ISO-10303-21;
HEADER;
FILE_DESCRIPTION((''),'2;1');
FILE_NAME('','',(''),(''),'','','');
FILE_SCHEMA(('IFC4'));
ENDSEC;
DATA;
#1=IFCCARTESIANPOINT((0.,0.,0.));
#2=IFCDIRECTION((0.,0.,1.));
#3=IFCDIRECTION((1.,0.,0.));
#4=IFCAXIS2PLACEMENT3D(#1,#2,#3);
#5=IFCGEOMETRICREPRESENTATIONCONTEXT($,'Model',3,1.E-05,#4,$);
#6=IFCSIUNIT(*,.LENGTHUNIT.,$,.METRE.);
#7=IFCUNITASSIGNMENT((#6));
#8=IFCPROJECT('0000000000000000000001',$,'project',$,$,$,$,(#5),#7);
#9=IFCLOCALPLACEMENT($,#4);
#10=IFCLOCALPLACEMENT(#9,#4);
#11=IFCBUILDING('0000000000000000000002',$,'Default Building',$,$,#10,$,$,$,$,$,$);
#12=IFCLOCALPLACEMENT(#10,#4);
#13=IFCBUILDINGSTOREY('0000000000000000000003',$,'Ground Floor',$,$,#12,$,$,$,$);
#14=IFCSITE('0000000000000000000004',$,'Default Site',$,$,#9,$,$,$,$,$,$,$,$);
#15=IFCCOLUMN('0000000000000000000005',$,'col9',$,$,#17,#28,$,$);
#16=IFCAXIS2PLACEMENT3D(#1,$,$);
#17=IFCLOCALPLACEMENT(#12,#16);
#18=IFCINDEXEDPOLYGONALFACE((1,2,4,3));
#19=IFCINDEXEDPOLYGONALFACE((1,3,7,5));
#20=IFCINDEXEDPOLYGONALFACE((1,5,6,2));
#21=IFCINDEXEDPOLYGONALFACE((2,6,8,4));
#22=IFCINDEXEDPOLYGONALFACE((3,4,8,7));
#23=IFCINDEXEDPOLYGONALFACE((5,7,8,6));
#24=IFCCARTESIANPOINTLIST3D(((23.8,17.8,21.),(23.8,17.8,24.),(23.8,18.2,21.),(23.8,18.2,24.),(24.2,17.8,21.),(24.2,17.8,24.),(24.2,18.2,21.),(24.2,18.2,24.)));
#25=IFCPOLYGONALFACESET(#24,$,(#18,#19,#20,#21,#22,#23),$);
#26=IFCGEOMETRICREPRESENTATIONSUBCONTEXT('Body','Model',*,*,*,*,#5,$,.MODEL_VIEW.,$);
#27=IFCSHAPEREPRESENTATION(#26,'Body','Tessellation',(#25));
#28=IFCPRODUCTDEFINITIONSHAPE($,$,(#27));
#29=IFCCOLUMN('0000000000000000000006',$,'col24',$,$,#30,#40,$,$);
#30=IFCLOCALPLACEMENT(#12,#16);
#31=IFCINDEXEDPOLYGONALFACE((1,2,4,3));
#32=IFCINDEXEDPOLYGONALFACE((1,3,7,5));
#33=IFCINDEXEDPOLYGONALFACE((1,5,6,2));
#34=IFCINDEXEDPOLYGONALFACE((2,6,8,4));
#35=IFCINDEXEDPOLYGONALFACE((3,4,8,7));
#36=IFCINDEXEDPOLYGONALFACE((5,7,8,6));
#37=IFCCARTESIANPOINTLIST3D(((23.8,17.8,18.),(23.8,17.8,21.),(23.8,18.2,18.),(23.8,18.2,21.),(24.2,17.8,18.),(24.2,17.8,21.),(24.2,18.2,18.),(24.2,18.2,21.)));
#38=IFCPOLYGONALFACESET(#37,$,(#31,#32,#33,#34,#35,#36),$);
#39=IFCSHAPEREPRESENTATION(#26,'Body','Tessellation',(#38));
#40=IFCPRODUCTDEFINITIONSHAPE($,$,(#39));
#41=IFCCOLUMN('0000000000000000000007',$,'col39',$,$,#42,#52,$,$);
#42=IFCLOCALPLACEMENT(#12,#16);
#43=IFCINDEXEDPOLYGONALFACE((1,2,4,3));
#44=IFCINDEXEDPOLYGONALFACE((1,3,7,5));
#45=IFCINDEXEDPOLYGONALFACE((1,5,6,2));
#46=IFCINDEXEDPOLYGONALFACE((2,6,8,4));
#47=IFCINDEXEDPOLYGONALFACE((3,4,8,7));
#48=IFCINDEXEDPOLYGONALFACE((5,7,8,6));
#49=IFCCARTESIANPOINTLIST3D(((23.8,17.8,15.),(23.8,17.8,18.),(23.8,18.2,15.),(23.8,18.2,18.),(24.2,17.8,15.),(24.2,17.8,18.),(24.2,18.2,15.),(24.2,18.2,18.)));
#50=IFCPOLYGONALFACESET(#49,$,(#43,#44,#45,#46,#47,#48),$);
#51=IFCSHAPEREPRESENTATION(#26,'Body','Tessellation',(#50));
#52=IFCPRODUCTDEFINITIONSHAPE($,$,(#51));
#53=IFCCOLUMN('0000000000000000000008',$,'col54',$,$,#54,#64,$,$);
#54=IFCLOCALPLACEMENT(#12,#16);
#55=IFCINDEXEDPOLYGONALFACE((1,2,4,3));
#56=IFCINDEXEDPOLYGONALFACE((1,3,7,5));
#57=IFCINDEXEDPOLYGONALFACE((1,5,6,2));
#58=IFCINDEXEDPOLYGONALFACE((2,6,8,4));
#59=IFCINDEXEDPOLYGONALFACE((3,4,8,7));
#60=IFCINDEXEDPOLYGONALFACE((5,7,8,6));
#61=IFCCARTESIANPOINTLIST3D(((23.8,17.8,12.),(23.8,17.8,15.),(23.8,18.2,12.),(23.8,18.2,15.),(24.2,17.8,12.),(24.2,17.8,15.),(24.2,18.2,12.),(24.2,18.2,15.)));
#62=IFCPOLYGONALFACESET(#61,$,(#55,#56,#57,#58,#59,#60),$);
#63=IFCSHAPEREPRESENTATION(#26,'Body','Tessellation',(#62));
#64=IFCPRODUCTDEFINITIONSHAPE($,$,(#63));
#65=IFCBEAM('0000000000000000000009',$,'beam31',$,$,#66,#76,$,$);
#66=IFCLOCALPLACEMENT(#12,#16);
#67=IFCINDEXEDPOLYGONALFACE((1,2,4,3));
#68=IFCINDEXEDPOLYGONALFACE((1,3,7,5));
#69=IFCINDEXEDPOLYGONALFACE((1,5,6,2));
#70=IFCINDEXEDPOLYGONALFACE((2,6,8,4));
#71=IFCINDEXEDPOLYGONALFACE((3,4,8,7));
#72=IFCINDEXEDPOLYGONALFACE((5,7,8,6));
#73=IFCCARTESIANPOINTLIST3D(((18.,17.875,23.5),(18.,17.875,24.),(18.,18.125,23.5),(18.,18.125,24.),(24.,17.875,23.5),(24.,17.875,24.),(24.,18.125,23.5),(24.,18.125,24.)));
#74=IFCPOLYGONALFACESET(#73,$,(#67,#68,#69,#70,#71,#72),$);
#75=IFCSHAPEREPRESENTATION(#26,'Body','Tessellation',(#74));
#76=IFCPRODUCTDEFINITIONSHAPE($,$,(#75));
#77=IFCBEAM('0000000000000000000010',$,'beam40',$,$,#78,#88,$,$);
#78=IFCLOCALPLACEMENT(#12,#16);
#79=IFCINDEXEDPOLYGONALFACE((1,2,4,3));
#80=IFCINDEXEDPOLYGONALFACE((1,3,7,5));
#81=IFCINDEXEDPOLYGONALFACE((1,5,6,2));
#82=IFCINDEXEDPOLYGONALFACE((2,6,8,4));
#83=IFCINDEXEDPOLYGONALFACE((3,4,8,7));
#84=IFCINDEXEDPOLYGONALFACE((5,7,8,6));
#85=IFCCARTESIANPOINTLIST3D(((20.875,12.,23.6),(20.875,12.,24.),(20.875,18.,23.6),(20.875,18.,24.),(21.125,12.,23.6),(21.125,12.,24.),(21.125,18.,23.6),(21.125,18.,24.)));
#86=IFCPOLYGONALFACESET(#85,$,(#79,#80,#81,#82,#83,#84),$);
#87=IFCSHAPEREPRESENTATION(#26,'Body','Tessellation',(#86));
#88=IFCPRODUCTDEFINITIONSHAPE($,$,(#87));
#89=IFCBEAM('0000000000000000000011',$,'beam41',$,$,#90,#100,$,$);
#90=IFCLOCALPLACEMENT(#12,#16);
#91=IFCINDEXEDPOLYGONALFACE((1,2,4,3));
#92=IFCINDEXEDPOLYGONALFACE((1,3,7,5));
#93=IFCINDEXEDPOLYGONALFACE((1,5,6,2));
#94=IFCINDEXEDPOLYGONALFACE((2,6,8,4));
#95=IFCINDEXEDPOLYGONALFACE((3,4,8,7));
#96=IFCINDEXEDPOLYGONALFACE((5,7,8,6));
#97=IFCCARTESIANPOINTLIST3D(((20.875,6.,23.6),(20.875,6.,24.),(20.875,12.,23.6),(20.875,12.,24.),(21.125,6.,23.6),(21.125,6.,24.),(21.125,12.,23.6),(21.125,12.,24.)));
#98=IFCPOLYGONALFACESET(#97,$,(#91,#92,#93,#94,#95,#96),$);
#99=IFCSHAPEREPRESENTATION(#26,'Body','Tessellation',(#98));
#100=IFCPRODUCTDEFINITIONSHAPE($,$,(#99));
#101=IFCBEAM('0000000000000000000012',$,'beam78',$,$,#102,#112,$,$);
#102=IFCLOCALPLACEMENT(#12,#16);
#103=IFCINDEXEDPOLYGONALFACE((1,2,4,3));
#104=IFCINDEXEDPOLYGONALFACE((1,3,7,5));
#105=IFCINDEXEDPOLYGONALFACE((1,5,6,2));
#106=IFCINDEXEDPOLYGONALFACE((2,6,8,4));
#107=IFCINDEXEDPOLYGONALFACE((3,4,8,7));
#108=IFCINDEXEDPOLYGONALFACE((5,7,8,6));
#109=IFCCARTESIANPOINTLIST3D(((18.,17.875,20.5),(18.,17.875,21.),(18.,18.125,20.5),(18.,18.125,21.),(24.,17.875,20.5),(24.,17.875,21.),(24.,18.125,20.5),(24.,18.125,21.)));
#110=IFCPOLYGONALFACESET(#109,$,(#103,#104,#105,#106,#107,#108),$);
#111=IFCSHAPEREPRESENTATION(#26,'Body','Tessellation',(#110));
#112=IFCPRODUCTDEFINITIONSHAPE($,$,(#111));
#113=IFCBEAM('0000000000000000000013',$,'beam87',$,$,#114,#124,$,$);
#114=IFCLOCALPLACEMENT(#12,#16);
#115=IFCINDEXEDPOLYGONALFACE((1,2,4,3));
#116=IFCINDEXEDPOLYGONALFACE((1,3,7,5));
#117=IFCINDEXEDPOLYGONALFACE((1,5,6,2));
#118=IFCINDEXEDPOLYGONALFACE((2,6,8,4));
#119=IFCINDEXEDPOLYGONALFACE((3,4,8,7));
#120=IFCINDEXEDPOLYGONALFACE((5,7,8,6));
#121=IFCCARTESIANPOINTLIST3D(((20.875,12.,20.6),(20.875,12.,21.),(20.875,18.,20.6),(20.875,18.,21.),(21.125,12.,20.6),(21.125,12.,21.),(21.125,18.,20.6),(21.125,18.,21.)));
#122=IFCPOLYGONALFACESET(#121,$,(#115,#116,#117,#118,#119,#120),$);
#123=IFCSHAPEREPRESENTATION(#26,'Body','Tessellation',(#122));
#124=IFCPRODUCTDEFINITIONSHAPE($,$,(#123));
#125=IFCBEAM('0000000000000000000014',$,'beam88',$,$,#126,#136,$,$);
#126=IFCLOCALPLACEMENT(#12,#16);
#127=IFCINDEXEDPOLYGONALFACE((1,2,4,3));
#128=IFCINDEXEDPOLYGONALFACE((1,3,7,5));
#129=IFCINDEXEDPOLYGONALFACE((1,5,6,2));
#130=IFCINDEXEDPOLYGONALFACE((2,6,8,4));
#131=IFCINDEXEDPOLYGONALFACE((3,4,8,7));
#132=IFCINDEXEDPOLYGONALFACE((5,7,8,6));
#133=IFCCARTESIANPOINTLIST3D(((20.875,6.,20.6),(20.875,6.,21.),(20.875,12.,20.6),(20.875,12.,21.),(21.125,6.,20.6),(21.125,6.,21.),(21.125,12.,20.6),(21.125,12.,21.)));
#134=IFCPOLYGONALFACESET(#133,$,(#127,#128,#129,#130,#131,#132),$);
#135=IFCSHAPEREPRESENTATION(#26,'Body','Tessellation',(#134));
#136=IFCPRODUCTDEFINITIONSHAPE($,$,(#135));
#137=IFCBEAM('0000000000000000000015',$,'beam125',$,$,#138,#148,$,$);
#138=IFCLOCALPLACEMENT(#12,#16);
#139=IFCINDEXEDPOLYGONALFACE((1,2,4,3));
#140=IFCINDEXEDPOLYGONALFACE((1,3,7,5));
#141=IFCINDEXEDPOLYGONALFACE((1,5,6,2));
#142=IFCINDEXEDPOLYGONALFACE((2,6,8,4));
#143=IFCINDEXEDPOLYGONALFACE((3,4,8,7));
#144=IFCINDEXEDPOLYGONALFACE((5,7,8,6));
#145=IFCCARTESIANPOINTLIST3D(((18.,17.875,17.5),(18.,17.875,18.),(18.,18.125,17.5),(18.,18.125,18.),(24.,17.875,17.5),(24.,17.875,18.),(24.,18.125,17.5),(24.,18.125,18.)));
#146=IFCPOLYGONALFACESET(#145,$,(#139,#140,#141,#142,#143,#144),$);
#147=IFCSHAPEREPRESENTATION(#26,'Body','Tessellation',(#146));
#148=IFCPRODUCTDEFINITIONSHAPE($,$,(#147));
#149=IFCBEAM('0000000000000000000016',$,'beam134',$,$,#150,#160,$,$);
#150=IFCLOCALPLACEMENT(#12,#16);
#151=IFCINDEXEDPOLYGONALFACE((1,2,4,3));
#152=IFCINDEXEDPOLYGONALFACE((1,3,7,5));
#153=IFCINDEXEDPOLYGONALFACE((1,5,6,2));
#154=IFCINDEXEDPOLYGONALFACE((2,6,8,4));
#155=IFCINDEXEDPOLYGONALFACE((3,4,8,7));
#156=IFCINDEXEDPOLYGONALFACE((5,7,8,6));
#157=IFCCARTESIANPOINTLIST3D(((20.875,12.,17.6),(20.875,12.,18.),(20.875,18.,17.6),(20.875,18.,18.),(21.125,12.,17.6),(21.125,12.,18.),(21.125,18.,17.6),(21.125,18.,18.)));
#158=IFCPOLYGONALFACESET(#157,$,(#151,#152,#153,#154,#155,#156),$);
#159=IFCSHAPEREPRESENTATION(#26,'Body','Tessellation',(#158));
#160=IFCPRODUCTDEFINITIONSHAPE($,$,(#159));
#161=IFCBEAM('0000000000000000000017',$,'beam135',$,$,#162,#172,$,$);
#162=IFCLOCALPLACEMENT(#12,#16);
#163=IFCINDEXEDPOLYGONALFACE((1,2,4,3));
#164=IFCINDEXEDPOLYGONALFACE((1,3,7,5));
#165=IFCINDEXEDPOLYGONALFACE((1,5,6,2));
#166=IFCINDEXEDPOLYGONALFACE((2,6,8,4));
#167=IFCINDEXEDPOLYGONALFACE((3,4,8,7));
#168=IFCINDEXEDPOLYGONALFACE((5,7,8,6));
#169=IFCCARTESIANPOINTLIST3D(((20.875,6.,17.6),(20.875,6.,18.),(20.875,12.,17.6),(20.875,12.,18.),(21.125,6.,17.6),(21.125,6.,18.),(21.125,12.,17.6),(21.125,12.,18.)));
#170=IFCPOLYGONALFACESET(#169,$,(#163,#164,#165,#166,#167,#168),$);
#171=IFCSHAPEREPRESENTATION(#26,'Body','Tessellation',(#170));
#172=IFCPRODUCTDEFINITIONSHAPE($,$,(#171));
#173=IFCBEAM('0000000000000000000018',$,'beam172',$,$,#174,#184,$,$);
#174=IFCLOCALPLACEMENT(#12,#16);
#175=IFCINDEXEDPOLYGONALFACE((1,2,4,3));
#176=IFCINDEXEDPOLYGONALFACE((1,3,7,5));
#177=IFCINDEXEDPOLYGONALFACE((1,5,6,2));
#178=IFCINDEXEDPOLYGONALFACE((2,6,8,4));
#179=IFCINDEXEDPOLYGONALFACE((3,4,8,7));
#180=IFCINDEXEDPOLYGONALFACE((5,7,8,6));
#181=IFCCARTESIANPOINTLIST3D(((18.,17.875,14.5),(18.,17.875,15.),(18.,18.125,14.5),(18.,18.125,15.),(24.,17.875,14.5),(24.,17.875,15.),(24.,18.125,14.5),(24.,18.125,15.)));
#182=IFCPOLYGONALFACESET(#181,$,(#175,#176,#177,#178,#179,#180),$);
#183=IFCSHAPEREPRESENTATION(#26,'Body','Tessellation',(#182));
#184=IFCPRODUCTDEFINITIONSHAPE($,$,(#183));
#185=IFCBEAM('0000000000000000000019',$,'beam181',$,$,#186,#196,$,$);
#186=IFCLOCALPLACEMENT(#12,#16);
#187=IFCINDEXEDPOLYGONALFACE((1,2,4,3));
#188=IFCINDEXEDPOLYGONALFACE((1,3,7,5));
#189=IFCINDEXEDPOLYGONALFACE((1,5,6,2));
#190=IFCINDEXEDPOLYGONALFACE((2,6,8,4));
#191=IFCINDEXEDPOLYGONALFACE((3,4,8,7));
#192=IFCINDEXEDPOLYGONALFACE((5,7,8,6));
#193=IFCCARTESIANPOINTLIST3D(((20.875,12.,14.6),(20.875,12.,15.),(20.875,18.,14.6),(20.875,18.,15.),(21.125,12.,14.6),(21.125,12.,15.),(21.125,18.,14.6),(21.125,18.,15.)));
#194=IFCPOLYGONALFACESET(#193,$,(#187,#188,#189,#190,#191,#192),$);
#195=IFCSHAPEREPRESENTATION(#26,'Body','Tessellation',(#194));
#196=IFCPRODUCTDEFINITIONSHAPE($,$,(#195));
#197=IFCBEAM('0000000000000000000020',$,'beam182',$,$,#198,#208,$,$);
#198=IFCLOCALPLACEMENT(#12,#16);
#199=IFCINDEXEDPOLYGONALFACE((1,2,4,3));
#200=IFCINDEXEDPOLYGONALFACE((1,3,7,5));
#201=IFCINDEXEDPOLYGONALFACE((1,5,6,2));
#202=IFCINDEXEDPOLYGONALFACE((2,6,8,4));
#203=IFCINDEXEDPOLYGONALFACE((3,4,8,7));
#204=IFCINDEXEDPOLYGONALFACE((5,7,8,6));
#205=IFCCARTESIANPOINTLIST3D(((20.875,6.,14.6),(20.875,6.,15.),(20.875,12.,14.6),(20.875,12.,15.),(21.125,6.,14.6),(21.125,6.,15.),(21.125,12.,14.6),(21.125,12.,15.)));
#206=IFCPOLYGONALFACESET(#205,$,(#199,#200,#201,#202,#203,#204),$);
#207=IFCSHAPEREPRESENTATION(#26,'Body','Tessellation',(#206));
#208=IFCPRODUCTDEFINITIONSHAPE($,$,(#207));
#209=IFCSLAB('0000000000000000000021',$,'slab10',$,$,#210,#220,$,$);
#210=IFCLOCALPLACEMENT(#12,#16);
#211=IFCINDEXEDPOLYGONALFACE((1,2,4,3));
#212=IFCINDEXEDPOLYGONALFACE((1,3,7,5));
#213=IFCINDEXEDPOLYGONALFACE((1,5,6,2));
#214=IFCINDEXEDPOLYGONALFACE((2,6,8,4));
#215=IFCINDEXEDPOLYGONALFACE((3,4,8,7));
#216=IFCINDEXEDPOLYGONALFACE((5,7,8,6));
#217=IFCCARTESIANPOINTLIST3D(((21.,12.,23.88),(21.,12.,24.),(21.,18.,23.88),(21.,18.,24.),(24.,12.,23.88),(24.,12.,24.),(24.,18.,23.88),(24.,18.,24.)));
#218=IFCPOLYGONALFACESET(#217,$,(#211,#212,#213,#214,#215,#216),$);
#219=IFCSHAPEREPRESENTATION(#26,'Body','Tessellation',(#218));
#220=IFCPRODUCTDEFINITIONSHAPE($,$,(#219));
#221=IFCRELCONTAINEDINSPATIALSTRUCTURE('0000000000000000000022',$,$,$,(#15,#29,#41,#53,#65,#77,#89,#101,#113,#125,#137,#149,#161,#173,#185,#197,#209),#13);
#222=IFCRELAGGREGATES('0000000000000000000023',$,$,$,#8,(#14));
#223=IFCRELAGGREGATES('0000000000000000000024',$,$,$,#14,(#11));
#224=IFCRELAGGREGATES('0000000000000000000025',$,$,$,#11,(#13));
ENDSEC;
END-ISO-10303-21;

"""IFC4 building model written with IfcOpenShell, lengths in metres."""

from ifc_helpers import new_model, si_unit, frame, origin_with_axes, place, context, subcontext, project, spatial, indexed_curve, outline, extrude, element, save


model = new_model("IFC4")

# Units and contexts
model_context = context("Model", 3, precision=1e-05, world=origin_with_axes())
body_context = subcontext(model_context, "Body", "Model", "MODEL_VIEW")
ifc_project = project(units=[si_unit("LENGTHUNIT", "METRE")], contexts=[model_context])

# Site, building, storey
site_placement = place(None, origin_with_axes())
site = spatial("IfcSite", under=ifc_project, at=site_placement, Name="Default Site")
building_placement = place(site_placement, origin_with_axes())
building = spatial("IfcBuilding", under=site, at=building_placement, Name="Default Building")
storey_placement = place(building_placement, origin_with_axes())
storey = spatial("IfcBuildingStorey", under=building, at=storey_placement, Name="Ground Floor")

# Columns
for number, where, z_axis, x_axis, name in (
    (1, (23.8, 17.8, 21.0), (0.0, 0.0, 1.0), (1.0, 0.0, 0.0), "col9"),
    (2, (23.8, 17.8, 18.0), (0.0, 0.0, 1.0), (1.0, 0.0, 0.0), "col24"),
    (3, (23.8, 17.8, 15.0), (0.0, 0.0, 1.0), (1.0, 0.0, 0.0), "col39"),
    (4, (23.8, 17.8, 12.0), (0.0, 0.0, 1.0), (1.0, 0.0, 0.0), "col54"),
):
    element("IfcColumn", number, at=place(storey_placement, frame(where, z_axis=z_axis, x_axis=x_axis)), inside=storey, Name=name, context=body_context, shape_type="SweptSolid", body=[
        extrude(outline(indexed_curve([(0.0, 0.0), (0.0, 0.4), (0.4, 0.4), (0.4, 0.0), (0.0, 0.0)], self_intersect=False)), origin_with_axes(), (0.0, 0.0, 1.0), 3.0),
    ])

# Beams
beam_1_placement = place(storey_placement, frame((18.0, 17.875, 23.5), z_axis=(0.0, 0.0, 1.0), x_axis=(1.0, 0.0, 0.0)))
element("IfcBeam", 5, at=beam_1_placement, inside=storey, Name="beam31", context=body_context, shape_type="SweptSolid", body=[
    extrude(outline(indexed_curve([(0.0, 0.0), (0.0, 0.25), (6.0, 0.25), (6.0, 0.0), (0.0, 0.0)], self_intersect=False)), origin_with_axes(), (0.0, 0.0, 1.0), 0.5),
])
for number, where, z_axis, x_axis, name in (
    (6, (20.875, 18.0, 23.6), (0.0, 0.0, 1.0), (0.0, -1.0, 0.0), "beam40"),
    (7, (20.875, 12.0, 23.6), (0.0, 0.0, 1.0), (0.0, -1.0, 0.0), "beam41"),
):
    element("IfcBeam", number, at=place(storey_placement, frame(where, z_axis=z_axis, x_axis=x_axis)), inside=storey, Name=name, context=body_context, shape_type="SweptSolid", body=[
        extrude(outline(indexed_curve([(0.0, 0.0), (0.0, 0.25), (6.0, 0.25), (6.0, 0.0), (0.0, 0.0)], self_intersect=False)), origin_with_axes(), (0.0, 0.0, 1.0), 0.4),
    ])
beam_2_placement = place(storey_placement, frame((18.0, 17.875, 20.5), z_axis=(0.0, 0.0, 1.0), x_axis=(1.0, 0.0, 0.0)))
element("IfcBeam", 8, at=beam_2_placement, inside=storey, Name="beam78", context=body_context, shape_type="SweptSolid", body=[
    extrude(outline(indexed_curve([(0.0, 0.0), (0.0, 0.25), (6.0, 0.25), (6.0, 0.0), (0.0, 0.0)], self_intersect=False)), origin_with_axes(), (0.0, 0.0, 1.0), 0.5),
])
for number, where, z_axis, x_axis, name in (
    (9, (20.875, 18.0, 20.6), (0.0, 0.0, 1.0), (0.0, -1.0, 0.0), "beam87"),
    (10, (20.875, 12.0, 20.6), (0.0, 0.0, 1.0), (0.0, -1.0, 0.0), "beam88"),
):
    element("IfcBeam", number, at=place(storey_placement, frame(where, z_axis=z_axis, x_axis=x_axis)), inside=storey, Name=name, context=body_context, shape_type="SweptSolid", body=[
        extrude(outline(indexed_curve([(0.0, 0.0), (0.0, 0.25), (6.0, 0.25), (6.0, 0.0), (0.0, 0.0)], self_intersect=False)), origin_with_axes(), (0.0, 0.0, 1.0), 0.4),
    ])
beam_3_placement = place(storey_placement, frame((18.0, 17.875, 17.5), z_axis=(0.0, 0.0, 1.0), x_axis=(1.0, 0.0, 0.0)))
element("IfcBeam", 11, at=beam_3_placement, inside=storey, Name="beam125", context=body_context, shape_type="SweptSolid", body=[
    extrude(outline(indexed_curve([(0.0, 0.0), (0.0, 0.25), (6.0, 0.25), (6.0, 0.0), (0.0, 0.0)], self_intersect=False)), origin_with_axes(), (0.0, 0.0, 1.0), 0.5),
])
for number, where, z_axis, x_axis, name in (
    (12, (20.875, 18.0, 17.6), (0.0, 0.0, 1.0), (0.0, -1.0, 0.0), "beam134"),
    (13, (20.875, 12.0, 17.6), (0.0, 0.0, 1.0), (0.0, -1.0, 0.0), "beam135"),
):
    element("IfcBeam", number, at=place(storey_placement, frame(where, z_axis=z_axis, x_axis=x_axis)), inside=storey, Name=name, context=body_context, shape_type="SweptSolid", body=[
        extrude(outline(indexed_curve([(0.0, 0.0), (0.0, 0.25), (6.0, 0.25), (6.0, 0.0), (0.0, 0.0)], self_intersect=False)), origin_with_axes(), (0.0, 0.0, 1.0), 0.4),
    ])
beam_4_placement = place(storey_placement, frame((18.0, 17.875, 14.5), z_axis=(0.0, 0.0, 1.0), x_axis=(1.0, 0.0, 0.0)))
element("IfcBeam", 14, at=beam_4_placement, inside=storey, Name="beam172", context=body_context, shape_type="SweptSolid", body=[
    extrude(outline(indexed_curve([(0.0, 0.0), (0.0, 0.25), (6.0, 0.25), (6.0, 0.0), (0.0, 0.0)], self_intersect=False)), origin_with_axes(), (0.0, 0.0, 1.0), 0.5),
])
for number, where, z_axis, x_axis, name in (
    (15, (20.875, 18.0, 14.6), (0.0, 0.0, 1.0), (0.0, -1.0, 0.0), "beam181"),
    (16, (20.875, 12.0, 14.6), (0.0, 0.0, 1.0), (0.0, -1.0, 0.0), "beam182"),
):
    element("IfcBeam", number, at=place(storey_placement, frame(where, z_axis=z_axis, x_axis=x_axis)), inside=storey, Name=name, context=body_context, shape_type="SweptSolid", body=[
        extrude(outline(indexed_curve([(0.0, 0.0), (0.0, 0.25), (6.0, 0.25), (6.0, 0.0), (0.0, 0.0)], self_intersect=False)), origin_with_axes(), (0.0, 0.0, 1.0), 0.4),
    ])

# Slab
for number, where, z_axis, x_axis, name in (
    (17, (21.0, 12.0, 23.88), (0.0, 0.0, 1.0), (1.0, 0.0, 0.0), "slab10"),
):
    element("IfcSlab", number, at=place(storey_placement, frame(where, z_axis=z_axis, x_axis=x_axis)), inside=storey, Name=name, context=body_context, shape_type="SweptSolid", body=[
        extrude(outline(indexed_curve([(0.0, 0.0), (0.0, 6.0), (3.0, 6.0), (3.0, 0.0), (0.0, 0.0)], self_intersect=False)), origin_with_axes(), (0.0, 0.0, 1.0), 0.12),
    ])

save(model, "model.ifc")
